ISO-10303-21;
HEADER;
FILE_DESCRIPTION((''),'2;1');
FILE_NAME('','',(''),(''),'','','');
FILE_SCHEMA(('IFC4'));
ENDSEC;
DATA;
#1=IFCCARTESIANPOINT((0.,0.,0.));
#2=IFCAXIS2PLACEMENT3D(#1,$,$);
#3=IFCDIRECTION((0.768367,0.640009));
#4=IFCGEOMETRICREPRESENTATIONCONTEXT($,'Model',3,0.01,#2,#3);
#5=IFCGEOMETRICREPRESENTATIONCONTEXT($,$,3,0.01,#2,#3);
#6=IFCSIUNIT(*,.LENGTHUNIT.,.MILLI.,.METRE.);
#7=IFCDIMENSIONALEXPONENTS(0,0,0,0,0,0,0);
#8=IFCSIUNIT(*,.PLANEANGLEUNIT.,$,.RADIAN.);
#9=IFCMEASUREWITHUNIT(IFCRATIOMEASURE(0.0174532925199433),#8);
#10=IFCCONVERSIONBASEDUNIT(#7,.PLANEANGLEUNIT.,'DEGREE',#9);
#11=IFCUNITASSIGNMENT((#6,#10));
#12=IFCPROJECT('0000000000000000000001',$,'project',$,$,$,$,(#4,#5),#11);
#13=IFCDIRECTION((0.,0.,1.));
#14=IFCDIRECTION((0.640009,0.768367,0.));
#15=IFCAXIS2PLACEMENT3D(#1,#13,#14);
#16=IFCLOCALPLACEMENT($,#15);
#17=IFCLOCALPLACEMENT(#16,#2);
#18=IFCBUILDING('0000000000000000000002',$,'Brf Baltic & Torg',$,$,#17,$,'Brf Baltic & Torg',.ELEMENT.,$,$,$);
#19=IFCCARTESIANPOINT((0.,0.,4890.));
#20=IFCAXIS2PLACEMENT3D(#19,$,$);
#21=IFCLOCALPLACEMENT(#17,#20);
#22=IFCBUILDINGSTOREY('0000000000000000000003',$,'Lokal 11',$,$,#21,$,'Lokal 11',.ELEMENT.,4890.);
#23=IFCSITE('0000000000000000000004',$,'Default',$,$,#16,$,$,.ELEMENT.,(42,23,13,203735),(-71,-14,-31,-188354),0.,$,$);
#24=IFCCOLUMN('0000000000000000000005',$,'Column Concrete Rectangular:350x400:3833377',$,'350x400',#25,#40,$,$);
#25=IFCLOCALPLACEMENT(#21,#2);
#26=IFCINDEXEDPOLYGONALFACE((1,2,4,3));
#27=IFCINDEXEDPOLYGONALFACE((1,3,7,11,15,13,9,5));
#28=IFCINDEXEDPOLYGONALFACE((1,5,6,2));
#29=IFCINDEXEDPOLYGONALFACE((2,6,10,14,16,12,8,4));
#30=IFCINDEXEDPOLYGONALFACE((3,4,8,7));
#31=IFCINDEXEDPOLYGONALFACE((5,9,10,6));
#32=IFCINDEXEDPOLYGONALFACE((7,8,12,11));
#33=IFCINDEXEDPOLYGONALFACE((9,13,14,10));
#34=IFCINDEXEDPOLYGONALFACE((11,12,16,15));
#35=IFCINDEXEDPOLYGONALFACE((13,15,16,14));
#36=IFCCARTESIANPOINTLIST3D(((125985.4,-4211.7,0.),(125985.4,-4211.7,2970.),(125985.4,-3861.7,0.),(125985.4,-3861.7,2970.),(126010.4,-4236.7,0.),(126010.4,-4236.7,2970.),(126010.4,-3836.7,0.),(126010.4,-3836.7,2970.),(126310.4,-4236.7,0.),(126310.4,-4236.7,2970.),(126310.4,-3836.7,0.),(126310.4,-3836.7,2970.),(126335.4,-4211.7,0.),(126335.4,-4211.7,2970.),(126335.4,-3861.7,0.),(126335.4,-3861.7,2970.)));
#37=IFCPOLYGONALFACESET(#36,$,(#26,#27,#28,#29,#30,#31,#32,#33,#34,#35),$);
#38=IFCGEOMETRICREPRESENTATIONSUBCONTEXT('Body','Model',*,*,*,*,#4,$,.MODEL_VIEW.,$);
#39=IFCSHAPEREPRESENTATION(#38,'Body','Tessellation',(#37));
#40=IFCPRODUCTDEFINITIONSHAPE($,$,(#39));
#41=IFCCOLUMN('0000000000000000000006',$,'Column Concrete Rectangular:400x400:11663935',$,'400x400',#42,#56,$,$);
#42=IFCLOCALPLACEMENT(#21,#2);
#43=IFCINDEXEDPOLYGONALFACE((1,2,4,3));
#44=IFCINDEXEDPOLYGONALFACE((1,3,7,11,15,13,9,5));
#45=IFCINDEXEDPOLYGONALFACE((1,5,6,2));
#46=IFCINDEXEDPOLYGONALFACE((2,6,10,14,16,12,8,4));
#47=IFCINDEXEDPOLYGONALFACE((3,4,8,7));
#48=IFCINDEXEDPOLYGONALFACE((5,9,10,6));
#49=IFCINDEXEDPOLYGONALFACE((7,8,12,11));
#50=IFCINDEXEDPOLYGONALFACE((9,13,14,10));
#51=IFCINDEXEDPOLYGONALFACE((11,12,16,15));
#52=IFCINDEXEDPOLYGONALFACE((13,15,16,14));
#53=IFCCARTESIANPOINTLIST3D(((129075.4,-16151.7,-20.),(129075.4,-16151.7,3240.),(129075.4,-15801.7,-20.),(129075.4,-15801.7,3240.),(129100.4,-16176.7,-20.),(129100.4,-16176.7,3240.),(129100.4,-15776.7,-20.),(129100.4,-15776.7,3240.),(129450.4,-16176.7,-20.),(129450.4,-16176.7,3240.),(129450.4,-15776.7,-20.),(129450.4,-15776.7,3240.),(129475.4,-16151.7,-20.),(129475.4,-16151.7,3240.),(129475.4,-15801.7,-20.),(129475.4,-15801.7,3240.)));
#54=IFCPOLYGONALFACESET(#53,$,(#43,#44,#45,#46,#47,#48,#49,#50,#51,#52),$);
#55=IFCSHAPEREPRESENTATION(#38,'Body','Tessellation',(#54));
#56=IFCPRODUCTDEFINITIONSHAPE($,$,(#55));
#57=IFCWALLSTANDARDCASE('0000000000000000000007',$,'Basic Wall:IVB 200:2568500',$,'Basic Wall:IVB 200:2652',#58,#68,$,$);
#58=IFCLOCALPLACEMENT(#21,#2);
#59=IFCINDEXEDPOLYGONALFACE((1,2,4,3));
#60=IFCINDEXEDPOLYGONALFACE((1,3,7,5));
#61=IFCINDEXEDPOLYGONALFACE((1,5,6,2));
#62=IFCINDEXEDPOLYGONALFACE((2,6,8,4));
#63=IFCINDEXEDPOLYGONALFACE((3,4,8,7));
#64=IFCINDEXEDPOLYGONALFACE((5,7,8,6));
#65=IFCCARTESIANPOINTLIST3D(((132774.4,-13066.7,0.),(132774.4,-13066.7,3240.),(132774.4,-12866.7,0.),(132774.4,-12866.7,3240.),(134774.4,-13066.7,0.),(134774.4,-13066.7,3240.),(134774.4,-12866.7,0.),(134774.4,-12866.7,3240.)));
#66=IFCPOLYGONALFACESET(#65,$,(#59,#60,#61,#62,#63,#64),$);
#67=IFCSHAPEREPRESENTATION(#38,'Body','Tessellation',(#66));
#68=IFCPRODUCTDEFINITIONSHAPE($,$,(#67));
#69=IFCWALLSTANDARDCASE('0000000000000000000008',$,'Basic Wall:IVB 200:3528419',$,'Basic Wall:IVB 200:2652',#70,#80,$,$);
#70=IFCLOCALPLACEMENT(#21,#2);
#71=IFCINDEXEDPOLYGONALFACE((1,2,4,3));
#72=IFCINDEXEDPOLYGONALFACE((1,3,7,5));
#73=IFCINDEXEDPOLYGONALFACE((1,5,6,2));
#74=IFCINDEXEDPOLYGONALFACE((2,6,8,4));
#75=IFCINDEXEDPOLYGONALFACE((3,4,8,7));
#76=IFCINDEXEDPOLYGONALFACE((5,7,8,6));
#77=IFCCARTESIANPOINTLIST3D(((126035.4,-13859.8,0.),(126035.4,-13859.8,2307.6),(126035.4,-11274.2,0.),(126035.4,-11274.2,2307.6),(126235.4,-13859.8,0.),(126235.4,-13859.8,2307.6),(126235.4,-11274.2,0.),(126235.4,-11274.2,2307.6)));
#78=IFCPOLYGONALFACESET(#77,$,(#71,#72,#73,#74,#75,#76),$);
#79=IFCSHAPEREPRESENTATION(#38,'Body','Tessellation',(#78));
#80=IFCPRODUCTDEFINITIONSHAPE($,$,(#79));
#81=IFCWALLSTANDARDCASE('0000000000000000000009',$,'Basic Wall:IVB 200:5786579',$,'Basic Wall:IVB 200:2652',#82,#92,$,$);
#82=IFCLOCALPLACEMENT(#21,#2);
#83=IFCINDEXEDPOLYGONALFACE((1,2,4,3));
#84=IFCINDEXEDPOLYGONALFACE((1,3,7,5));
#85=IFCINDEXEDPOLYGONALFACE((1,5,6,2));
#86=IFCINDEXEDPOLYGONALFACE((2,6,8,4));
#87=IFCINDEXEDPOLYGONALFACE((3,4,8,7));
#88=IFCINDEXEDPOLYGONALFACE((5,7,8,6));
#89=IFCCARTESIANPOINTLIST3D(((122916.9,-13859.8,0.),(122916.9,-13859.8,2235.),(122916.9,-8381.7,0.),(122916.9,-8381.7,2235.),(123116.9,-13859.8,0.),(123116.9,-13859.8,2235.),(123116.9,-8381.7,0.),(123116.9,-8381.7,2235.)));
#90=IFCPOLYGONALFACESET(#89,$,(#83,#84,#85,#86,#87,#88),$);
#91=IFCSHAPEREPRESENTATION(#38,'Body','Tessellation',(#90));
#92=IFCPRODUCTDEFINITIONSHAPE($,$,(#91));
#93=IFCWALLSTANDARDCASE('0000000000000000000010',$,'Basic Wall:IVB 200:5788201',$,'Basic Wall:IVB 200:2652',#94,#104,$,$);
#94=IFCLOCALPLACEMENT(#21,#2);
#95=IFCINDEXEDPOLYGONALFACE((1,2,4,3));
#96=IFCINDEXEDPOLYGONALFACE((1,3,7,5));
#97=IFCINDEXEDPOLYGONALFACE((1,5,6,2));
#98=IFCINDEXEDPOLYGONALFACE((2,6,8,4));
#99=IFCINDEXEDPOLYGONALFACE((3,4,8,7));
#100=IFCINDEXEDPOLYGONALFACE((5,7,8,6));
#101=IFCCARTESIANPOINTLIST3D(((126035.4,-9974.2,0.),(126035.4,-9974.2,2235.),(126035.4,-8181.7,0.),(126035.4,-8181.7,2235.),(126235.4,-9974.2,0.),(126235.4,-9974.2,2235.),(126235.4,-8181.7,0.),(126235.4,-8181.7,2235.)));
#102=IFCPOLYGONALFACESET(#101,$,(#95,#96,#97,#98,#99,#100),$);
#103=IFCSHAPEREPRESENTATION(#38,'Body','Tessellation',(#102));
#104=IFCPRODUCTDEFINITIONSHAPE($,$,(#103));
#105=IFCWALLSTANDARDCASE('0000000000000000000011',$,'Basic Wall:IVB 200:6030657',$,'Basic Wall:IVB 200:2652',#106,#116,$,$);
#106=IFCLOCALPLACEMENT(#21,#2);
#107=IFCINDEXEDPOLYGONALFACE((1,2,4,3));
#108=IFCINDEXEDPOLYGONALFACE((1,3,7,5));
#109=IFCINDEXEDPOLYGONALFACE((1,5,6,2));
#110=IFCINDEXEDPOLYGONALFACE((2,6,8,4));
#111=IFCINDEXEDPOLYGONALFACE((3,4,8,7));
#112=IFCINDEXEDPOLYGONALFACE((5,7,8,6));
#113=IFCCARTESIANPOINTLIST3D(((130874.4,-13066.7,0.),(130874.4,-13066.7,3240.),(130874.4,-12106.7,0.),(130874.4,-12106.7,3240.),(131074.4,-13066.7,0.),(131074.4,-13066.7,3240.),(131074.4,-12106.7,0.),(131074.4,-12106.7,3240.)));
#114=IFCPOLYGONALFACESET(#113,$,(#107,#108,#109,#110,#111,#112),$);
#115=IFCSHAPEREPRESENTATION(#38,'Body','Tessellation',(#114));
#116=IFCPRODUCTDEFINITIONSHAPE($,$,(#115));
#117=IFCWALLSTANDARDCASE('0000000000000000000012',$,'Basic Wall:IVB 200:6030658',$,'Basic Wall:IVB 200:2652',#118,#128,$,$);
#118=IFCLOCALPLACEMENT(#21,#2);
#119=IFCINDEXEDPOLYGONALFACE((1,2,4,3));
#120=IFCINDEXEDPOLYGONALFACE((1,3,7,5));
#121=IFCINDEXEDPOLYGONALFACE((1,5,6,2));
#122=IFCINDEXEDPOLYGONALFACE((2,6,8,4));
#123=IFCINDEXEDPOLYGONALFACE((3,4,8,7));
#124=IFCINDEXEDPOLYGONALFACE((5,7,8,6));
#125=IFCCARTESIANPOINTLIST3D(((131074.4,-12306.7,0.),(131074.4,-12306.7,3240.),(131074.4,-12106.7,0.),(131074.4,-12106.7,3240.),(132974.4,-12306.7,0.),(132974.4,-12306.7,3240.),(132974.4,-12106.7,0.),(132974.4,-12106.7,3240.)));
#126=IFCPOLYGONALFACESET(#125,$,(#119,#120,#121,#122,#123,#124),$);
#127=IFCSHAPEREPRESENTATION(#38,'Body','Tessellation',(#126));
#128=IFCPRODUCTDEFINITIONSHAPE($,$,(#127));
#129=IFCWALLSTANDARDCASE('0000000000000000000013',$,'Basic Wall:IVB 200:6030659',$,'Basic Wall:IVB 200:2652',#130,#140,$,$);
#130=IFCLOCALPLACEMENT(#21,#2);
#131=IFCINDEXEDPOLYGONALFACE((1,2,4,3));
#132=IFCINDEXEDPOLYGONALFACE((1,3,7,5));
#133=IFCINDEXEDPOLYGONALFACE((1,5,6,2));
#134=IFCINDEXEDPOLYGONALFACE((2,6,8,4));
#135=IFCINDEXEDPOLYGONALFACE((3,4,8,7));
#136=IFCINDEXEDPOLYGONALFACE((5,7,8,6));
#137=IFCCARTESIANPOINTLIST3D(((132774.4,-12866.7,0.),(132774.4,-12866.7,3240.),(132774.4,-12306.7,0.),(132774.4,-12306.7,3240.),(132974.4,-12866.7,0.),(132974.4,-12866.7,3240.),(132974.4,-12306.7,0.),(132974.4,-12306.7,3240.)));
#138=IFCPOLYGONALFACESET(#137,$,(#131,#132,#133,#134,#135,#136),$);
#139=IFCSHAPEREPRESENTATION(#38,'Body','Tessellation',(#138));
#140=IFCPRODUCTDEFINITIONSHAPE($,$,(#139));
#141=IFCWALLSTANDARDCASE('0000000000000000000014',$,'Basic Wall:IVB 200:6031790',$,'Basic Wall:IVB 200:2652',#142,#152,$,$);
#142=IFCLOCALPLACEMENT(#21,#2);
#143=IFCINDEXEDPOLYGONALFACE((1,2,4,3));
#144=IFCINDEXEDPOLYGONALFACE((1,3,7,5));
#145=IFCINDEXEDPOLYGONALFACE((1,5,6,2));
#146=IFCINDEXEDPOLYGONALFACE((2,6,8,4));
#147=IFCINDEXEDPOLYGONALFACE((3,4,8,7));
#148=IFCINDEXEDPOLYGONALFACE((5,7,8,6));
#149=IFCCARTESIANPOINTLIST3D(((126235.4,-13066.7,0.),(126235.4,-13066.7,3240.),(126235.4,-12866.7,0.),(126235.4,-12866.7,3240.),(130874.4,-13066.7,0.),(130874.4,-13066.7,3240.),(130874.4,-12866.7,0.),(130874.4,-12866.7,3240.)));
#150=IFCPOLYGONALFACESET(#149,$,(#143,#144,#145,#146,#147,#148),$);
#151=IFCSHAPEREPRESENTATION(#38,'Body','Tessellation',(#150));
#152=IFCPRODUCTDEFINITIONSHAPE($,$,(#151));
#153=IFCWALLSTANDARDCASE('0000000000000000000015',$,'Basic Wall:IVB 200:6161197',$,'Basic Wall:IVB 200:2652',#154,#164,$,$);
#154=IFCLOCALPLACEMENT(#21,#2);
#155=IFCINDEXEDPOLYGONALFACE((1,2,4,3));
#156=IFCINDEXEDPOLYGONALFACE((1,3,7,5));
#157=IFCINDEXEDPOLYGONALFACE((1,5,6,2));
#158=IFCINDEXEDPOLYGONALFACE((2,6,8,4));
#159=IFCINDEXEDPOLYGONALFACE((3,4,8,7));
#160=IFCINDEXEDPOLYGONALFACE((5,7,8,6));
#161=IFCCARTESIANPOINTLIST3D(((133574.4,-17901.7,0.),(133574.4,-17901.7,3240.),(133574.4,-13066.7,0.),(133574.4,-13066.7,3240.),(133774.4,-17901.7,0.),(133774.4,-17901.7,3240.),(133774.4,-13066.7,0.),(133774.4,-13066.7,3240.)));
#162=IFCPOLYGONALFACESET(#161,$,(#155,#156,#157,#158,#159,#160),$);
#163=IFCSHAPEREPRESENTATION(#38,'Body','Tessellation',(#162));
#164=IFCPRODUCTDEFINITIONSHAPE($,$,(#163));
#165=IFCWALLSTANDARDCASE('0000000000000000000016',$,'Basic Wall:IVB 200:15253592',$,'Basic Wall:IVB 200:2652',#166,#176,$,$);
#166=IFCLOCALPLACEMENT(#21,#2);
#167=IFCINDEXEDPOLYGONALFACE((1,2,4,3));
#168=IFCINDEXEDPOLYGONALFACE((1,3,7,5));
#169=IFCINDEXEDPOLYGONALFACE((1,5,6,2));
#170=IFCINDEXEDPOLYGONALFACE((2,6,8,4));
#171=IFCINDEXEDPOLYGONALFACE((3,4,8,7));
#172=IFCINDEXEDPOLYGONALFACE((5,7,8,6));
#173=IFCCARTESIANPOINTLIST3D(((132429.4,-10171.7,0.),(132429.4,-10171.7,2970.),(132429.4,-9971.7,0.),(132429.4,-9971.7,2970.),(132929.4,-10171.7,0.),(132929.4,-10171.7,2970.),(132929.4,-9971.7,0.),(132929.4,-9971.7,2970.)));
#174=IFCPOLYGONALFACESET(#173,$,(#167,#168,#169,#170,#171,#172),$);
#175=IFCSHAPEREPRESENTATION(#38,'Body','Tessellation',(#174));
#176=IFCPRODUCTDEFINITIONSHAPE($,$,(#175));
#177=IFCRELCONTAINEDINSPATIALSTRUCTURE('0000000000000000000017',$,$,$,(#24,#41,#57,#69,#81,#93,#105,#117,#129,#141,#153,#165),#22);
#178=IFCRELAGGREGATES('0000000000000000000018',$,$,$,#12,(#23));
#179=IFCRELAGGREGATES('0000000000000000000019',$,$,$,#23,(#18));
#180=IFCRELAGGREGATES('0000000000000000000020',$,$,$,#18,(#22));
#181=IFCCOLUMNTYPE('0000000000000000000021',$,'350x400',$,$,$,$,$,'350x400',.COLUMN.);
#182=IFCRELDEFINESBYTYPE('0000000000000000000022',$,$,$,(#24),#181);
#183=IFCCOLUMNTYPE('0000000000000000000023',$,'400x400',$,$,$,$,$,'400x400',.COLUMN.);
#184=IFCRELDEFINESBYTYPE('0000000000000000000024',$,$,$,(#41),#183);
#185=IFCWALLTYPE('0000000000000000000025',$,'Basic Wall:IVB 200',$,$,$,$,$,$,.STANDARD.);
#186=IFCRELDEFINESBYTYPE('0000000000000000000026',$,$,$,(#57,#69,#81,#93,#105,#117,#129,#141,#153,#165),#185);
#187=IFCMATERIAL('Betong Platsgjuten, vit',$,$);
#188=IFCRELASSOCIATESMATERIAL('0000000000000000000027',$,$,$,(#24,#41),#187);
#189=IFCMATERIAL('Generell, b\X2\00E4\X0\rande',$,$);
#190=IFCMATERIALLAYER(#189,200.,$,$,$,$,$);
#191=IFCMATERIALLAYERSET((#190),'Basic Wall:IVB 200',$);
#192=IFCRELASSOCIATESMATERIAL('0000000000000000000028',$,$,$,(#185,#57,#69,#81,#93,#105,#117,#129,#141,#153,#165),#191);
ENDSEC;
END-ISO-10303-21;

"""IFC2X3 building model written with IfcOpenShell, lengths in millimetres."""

from ifc_helpers import new_model, entity, si_unit, converted_unit, direction, frame, frame_2d, origin, place, context, subcontext, project, spatial, polyline, rectangle, outline, extrude, clip, halfspace, source, transform, mapped, material, layer, layer_set, layer_usage, type_object, type_shapes, element, save


model = new_model("IFC2X3")

# Units and contexts
model_context = context("Model", 3, precision=0.01, world=origin(), true_north=direction((0.768367, 0.640009)))
context_of_model = context(None, 3, precision=0.01, world=origin(), true_north=direction((0.768367, 0.640009)))
body_context = subcontext(model_context, "Body", "Model", "MODEL_VIEW")
ifc_project = project(units=[si_unit("LENGTHUNIT", "METRE", prefix="MILLI"), converted_unit("PLANEANGLEUNIT", "DEGREE", entity("IfcRatioMeasure", 0.0174532925199433), si_unit("PLANEANGLEUNIT", "RADIAN"), dimensions=[0, 0, 0, 0, 0, 0, 0])], contexts=[model_context, context_of_model])

# Site, building, storey
site_placement = place(None, frame((0.0, 0.0, 0.0), z_axis=(0.0, 0.0, 1.0), x_axis=(0.640009, 0.768367, 0.0)))
site = spatial("IfcSite", under=ifc_project, at=site_placement, Name="Default", CompositionType="ELEMENT", RefLatitude=(42, 23, 13, 203735), RefLongitude=(-71, -14, -31, -188354), RefElevation=0.0)
building_placement = place(site_placement, origin())
building = spatial("IfcBuilding", under=site, at=building_placement, Name="Brf Baltic & Torg", LongName="Brf Baltic & Torg", CompositionType="ELEMENT")
storey_placement = place(building_placement, frame((0.0, 0.0, 4890.0)))
storey = spatial("IfcBuildingStorey", under=building, at=storey_placement, Name="Lokal 11", LongName="Lokal 11", CompositionType="ELEMENT", Elevation=4890.0)

# Columns
ifc_material_1 = material(Name="Betong Platsgjuten, vit")
column_type_1 = type_object("IfcColumnType", Name="350x400", ElementType="350x400", PredefinedType="COLUMN")
shared_shape_1 = source(origin(), body_context, "Body", "SweptSolid", [
    extrude(outline(polyline([(-175.0, -175.0), (175.0, -175.0), (200.0, -150.0), (200.0, 150.0), (175.0, 175.0), (-175.0, 175.0), (-200.0, 150.0), (-200.0, -150.0), (-175.0, -175.0)])), frame((0.0, 0.0, 4890.0), z_axis=(0.0, 0.0, 1.0), x_axis=(0.0, -1.0, 0.0)), (0.0, 0.0, 1.0), 2970.0),
])
type_shapes(column_type_1, [shared_shape_1])
column_1_placement = place(storey_placement, frame((126160.4, -4036.7, -4890.0)))
element("IfcColumn", 1, at=column_1_placement, inside=storey, type_object=column_type_1, material=ifc_material_1, Name="Column Concrete Rectangular:350x400:3833377", ObjectType="350x400", context=body_context, shape_type="MappedRepresentation", body=[
    mapped(shared_shape_1, transform((0.0, 0.0, 0.0), scale=1.0)),
])
column_type_2 = type_object("IfcColumnType", Name="400x400", ElementType="400x400", PredefinedType="COLUMN")
shared_shape_2 = source(origin(), body_context, "Body", "SweptSolid", [
    extrude(outline(polyline([(-175.0, -200.0), (175.0, -200.0), (200.0, -175.0), (200.0, 175.0), (175.0, 200.0), (-175.0, 200.0), (-200.0, 175.0), (-200.0, -175.0), (-175.0, -200.0)])), frame((0.0, 0.0, 4870.0), z_axis=(0.0, 0.0, 1.0), x_axis=(0.0, -1.0, 0.0)), (0.0, 0.0, 1.0), 3260.0),
])
type_shapes(column_type_2, [shared_shape_2])
column_2_placement = place(storey_placement, frame((129275.4, -15976.7, -4890.0)))
element("IfcColumn", 2, at=column_2_placement, inside=storey, type_object=column_type_2, material=ifc_material_1, Name="Column Concrete Rectangular:400x400:11663935", ObjectType="400x400", context=body_context, shape_type="MappedRepresentation", body=[
    mapped(shared_shape_2, transform((0.0, 0.0, 0.0), scale=1.0)),
])

# Shared definitions
ifc_material_2 = material(Name="Generell, bärande")
ifc_layer = layer(ifc_material_2, 200.0)
ifc_layer_set = layer_set([ifc_layer], Name="Basic Wall:IVB 200")
wall_type = type_object("IfcWallType", Name="Basic Wall:IVB 200", PredefinedType="STANDARD", material=ifc_layer_set)

# Wall
ifc_layer_usage_1 = layer_usage(ifc_layer_set, "AXIS2", "NEGATIVE", 100.0)
wall_1_placement = place(storey_placement, frame((134774.4, -12966.7, 0.0), z_axis=(0.0, 0.0, 1.0), x_axis=(-1.0, 0.0, 0.0)))
element("IfcWallStandardCase", 3, at=wall_1_placement, inside=storey, type_object=wall_type, material=ifc_layer_usage_1, Name="Basic Wall:IVB 200:2568500", ObjectType="Basic Wall:IVB 200:2652", context=body_context, shape_type="Clipping", body=[
    clip(extrude(rectangle(XDim=2000.0, YDim=200.0, at=frame_2d((1000.0, 0.0), x_axis=(-1.0, 0.0))), origin(), (0.0, 0.0, 1.0), 3240.0), halfspace(frame((0.0, 0.0, -265.0)), True)),
])

# Walls
ifc_layer_usage_2 = layer_usage(ifc_layer_set, "AXIS2", "NEGATIVE", 100.0)
wall_2_placement = place(storey_placement, frame((126135.4, -13859.8, 0.0), z_axis=(0.0, 0.0, 1.0), x_axis=(0.0, 1.0, 0.0)))
element("IfcWallStandardCase", 4, at=wall_2_placement, inside=storey, type_object=wall_type, material=ifc_layer_usage_2, Name="Basic Wall:IVB 200:3528419", ObjectType="Basic Wall:IVB 200:2652", context=body_context, shape_type="Clipping", body=[
    clip(extrude(rectangle(XDim=2585.6, YDim=200.0, at=frame_2d((1292.8, 0.0), x_axis=(-1.0, 0.0))), origin(), (0.0, 0.0, 1.0), 2307.6), halfspace(frame((0.0, 0.0, -265.0)), True)),
])
ifc_layer_usage_3 = layer_usage(ifc_layer_set, "AXIS2", "NEGATIVE", 100.0)
wall_3_placement = place(storey_placement, frame((123016.9, -13859.8, 0.0), z_axis=(0.0, 0.0, 1.0), x_axis=(0.0, 1.0, 0.0)))
element("IfcWallStandardCase", 5, at=wall_3_placement, inside=storey, type_object=wall_type, material=ifc_layer_usage_3, Name="Basic Wall:IVB 200:5786579", ObjectType="Basic Wall:IVB 200:2652", context=body_context, shape_type="Clipping", body=[
    clip(extrude(rectangle(XDim=5478.1, YDim=200.0, at=frame_2d((2739.0, 0.0), x_axis=(-1.0, 0.0))), origin(), (0.0, 0.0, 1.0), 2235.0), halfspace(frame((0.0, 0.0, -265.0)), True)),
])

# Walls
ifc_layer_usage_4 = layer_usage(ifc_layer_set, "AXIS2", "NEGATIVE", 100.0)
wall_4_placement = place(storey_placement, frame((126135.4, -9974.2, 0.0), z_axis=(0.0, 0.0, 1.0), x_axis=(0.0, 1.0, 0.0)))
element("IfcWallStandardCase", 6, at=wall_4_placement, inside=storey, type_object=wall_type, material=ifc_layer_usage_4, Name="Basic Wall:IVB 200:5788201", ObjectType="Basic Wall:IVB 200:2652", context=body_context, shape_type="Clipping", body=[
    clip(extrude(rectangle(XDim=1792.5, YDim=200.0, at=frame_2d((896.3, 0.0), x_axis=(-1.0, 0.0))), origin(), (0.0, 0.0, 1.0), 2235.0), halfspace(frame((0.0, 0.0, -265.0)), True)),
])
ifc_layer_usage_5 = layer_usage(ifc_layer_set, "AXIS2", "POSITIVE", -100.0)
wall_5_placement = place(storey_placement, frame((130974.4, -13066.7, 0.0), z_axis=(0.0, 0.0, 1.0), x_axis=(0.0, 1.0, 0.0)))
element("IfcWallStandardCase", 7, at=wall_5_placement, inside=storey, type_object=wall_type, material=ifc_layer_usage_5, Name="Basic Wall:IVB 200:6030657", ObjectType="Basic Wall:IVB 200:2652", context=body_context, shape_type="Clipping", body=[
    clip(extrude(rectangle(XDim=960.0, YDim=200.0, at=frame_2d((480.0, 0.0), x_axis=(-1.0, 0.0))), origin(), (0.0, 0.0, 1.0), 3240.0), halfspace(frame((0.0, 0.0, -265.0)), True)),
])
ifc_layer_usage_6 = layer_usage(ifc_layer_set, "AXIS2", "POSITIVE", -100.0)
wall_6_placement = place(storey_placement, frame((131074.4, -12206.7, 0.0)))
element("IfcWallStandardCase", 8, at=wall_6_placement, inside=storey, type_object=wall_type, material=ifc_layer_usage_6, Name="Basic Wall:IVB 200:6030658", ObjectType="Basic Wall:IVB 200:2652", context=body_context, shape_type="Clipping", body=[
    clip(extrude(rectangle(XDim=1900.0, YDim=200.0, at=frame_2d((950.0, 0.0), x_axis=(-1.0, 0.0))), origin(), (0.0, 0.0, 1.0), 3240.0), halfspace(frame((0.0, 0.0, -265.0)), True)),
])
ifc_layer_usage_7 = layer_usage(ifc_layer_set, "AXIS2", "POSITIVE", -100.0)
wall_7_placement = place(storey_placement, frame((132874.4, -12866.7, 0.0), z_axis=(0.0, 0.0, 1.0), x_axis=(0.0, 1.0, 0.0)))
element("IfcWallStandardCase", 9, at=wall_7_placement, inside=storey, type_object=wall_type, material=ifc_layer_usage_7, Name="Basic Wall:IVB 200:6030659", ObjectType="Basic Wall:IVB 200:2652", context=body_context, shape_type="Clipping", body=[
    clip(extrude(rectangle(XDim=560.0, YDim=200.0, at=frame_2d((280.0, 0.0), x_axis=(-1.0, 0.0))), origin(), (0.0, 0.0, 1.0), 3240.0), halfspace(frame((0.0, 0.0, -265.0)), True)),
])
ifc_layer_usage_8 = layer_usage(ifc_layer_set, "AXIS2", "NEGATIVE", 100.0)
wall_8_placement = place(storey_placement, frame((130874.4, -12966.7, 0.0), z_axis=(0.0, 0.0, 1.0), x_axis=(-1.0, 0.0, 0.0)))
element("IfcWallStandardCase", 10, at=wall_8_placement, inside=storey, type_object=wall_type, material=ifc_layer_usage_8, Name="Basic Wall:IVB 200:6031790", ObjectType="Basic Wall:IVB 200:2652", context=body_context, shape_type="Clipping", body=[
    clip(extrude(rectangle(XDim=4639.0, YDim=200.0, at=frame_2d((2319.5, 0.0), x_axis=(-1.0, 0.0))), origin(), (0.0, 0.0, 1.0), 3240.0), halfspace(frame((0.0, 0.0, -265.0)), True)),
])
ifc_layer_usage_9 = layer_usage(ifc_layer_set, "AXIS2", "NEGATIVE", 100.0)
wall_9_placement = place(storey_placement, frame((133674.4, -17901.7, 0.0), z_axis=(0.0, 0.0, 1.0), x_axis=(0.0, 1.0, 0.0)))
element("IfcWallStandardCase", 11, at=wall_9_placement, inside=storey, type_object=wall_type, material=ifc_layer_usage_9, Name="Basic Wall:IVB 200:6161197", ObjectType="Basic Wall:IVB 200:2652", context=body_context, shape_type="Clipping", body=[
    clip(extrude(rectangle(XDim=4835.0, YDim=200.0, at=frame_2d((2417.5, 0.0), x_axis=(-1.0, 0.0))), origin(), (0.0, 0.0, 1.0), 3240.0), halfspace(frame((0.0, 0.0, -3240.0)), True)),
])
ifc_layer_usage_10 = layer_usage(ifc_layer_set, "AXIS2", "NEGATIVE", 100.0)
wall_10_placement = place(storey_placement, frame((132429.4, -10071.7, 0.0)))
element("IfcWallStandardCase", 12, at=wall_10_placement, inside=storey, type_object=wall_type, material=ifc_layer_usage_10, Name="Basic Wall:IVB 200:15253592", ObjectType="Basic Wall:IVB 200:2652", context=body_context, shape_type="Clipping", body=[
    clip(extrude(rectangle(XDim=500.0, YDim=200.0, at=frame_2d((250.0, 0.0), x_axis=(-1.0, 0.0))), origin(), (0.0, 0.0, 1.0), 2970.0), halfspace(frame((0.0, 0.0, -265.0)), True)),
])

save(model, "model.ifc")
